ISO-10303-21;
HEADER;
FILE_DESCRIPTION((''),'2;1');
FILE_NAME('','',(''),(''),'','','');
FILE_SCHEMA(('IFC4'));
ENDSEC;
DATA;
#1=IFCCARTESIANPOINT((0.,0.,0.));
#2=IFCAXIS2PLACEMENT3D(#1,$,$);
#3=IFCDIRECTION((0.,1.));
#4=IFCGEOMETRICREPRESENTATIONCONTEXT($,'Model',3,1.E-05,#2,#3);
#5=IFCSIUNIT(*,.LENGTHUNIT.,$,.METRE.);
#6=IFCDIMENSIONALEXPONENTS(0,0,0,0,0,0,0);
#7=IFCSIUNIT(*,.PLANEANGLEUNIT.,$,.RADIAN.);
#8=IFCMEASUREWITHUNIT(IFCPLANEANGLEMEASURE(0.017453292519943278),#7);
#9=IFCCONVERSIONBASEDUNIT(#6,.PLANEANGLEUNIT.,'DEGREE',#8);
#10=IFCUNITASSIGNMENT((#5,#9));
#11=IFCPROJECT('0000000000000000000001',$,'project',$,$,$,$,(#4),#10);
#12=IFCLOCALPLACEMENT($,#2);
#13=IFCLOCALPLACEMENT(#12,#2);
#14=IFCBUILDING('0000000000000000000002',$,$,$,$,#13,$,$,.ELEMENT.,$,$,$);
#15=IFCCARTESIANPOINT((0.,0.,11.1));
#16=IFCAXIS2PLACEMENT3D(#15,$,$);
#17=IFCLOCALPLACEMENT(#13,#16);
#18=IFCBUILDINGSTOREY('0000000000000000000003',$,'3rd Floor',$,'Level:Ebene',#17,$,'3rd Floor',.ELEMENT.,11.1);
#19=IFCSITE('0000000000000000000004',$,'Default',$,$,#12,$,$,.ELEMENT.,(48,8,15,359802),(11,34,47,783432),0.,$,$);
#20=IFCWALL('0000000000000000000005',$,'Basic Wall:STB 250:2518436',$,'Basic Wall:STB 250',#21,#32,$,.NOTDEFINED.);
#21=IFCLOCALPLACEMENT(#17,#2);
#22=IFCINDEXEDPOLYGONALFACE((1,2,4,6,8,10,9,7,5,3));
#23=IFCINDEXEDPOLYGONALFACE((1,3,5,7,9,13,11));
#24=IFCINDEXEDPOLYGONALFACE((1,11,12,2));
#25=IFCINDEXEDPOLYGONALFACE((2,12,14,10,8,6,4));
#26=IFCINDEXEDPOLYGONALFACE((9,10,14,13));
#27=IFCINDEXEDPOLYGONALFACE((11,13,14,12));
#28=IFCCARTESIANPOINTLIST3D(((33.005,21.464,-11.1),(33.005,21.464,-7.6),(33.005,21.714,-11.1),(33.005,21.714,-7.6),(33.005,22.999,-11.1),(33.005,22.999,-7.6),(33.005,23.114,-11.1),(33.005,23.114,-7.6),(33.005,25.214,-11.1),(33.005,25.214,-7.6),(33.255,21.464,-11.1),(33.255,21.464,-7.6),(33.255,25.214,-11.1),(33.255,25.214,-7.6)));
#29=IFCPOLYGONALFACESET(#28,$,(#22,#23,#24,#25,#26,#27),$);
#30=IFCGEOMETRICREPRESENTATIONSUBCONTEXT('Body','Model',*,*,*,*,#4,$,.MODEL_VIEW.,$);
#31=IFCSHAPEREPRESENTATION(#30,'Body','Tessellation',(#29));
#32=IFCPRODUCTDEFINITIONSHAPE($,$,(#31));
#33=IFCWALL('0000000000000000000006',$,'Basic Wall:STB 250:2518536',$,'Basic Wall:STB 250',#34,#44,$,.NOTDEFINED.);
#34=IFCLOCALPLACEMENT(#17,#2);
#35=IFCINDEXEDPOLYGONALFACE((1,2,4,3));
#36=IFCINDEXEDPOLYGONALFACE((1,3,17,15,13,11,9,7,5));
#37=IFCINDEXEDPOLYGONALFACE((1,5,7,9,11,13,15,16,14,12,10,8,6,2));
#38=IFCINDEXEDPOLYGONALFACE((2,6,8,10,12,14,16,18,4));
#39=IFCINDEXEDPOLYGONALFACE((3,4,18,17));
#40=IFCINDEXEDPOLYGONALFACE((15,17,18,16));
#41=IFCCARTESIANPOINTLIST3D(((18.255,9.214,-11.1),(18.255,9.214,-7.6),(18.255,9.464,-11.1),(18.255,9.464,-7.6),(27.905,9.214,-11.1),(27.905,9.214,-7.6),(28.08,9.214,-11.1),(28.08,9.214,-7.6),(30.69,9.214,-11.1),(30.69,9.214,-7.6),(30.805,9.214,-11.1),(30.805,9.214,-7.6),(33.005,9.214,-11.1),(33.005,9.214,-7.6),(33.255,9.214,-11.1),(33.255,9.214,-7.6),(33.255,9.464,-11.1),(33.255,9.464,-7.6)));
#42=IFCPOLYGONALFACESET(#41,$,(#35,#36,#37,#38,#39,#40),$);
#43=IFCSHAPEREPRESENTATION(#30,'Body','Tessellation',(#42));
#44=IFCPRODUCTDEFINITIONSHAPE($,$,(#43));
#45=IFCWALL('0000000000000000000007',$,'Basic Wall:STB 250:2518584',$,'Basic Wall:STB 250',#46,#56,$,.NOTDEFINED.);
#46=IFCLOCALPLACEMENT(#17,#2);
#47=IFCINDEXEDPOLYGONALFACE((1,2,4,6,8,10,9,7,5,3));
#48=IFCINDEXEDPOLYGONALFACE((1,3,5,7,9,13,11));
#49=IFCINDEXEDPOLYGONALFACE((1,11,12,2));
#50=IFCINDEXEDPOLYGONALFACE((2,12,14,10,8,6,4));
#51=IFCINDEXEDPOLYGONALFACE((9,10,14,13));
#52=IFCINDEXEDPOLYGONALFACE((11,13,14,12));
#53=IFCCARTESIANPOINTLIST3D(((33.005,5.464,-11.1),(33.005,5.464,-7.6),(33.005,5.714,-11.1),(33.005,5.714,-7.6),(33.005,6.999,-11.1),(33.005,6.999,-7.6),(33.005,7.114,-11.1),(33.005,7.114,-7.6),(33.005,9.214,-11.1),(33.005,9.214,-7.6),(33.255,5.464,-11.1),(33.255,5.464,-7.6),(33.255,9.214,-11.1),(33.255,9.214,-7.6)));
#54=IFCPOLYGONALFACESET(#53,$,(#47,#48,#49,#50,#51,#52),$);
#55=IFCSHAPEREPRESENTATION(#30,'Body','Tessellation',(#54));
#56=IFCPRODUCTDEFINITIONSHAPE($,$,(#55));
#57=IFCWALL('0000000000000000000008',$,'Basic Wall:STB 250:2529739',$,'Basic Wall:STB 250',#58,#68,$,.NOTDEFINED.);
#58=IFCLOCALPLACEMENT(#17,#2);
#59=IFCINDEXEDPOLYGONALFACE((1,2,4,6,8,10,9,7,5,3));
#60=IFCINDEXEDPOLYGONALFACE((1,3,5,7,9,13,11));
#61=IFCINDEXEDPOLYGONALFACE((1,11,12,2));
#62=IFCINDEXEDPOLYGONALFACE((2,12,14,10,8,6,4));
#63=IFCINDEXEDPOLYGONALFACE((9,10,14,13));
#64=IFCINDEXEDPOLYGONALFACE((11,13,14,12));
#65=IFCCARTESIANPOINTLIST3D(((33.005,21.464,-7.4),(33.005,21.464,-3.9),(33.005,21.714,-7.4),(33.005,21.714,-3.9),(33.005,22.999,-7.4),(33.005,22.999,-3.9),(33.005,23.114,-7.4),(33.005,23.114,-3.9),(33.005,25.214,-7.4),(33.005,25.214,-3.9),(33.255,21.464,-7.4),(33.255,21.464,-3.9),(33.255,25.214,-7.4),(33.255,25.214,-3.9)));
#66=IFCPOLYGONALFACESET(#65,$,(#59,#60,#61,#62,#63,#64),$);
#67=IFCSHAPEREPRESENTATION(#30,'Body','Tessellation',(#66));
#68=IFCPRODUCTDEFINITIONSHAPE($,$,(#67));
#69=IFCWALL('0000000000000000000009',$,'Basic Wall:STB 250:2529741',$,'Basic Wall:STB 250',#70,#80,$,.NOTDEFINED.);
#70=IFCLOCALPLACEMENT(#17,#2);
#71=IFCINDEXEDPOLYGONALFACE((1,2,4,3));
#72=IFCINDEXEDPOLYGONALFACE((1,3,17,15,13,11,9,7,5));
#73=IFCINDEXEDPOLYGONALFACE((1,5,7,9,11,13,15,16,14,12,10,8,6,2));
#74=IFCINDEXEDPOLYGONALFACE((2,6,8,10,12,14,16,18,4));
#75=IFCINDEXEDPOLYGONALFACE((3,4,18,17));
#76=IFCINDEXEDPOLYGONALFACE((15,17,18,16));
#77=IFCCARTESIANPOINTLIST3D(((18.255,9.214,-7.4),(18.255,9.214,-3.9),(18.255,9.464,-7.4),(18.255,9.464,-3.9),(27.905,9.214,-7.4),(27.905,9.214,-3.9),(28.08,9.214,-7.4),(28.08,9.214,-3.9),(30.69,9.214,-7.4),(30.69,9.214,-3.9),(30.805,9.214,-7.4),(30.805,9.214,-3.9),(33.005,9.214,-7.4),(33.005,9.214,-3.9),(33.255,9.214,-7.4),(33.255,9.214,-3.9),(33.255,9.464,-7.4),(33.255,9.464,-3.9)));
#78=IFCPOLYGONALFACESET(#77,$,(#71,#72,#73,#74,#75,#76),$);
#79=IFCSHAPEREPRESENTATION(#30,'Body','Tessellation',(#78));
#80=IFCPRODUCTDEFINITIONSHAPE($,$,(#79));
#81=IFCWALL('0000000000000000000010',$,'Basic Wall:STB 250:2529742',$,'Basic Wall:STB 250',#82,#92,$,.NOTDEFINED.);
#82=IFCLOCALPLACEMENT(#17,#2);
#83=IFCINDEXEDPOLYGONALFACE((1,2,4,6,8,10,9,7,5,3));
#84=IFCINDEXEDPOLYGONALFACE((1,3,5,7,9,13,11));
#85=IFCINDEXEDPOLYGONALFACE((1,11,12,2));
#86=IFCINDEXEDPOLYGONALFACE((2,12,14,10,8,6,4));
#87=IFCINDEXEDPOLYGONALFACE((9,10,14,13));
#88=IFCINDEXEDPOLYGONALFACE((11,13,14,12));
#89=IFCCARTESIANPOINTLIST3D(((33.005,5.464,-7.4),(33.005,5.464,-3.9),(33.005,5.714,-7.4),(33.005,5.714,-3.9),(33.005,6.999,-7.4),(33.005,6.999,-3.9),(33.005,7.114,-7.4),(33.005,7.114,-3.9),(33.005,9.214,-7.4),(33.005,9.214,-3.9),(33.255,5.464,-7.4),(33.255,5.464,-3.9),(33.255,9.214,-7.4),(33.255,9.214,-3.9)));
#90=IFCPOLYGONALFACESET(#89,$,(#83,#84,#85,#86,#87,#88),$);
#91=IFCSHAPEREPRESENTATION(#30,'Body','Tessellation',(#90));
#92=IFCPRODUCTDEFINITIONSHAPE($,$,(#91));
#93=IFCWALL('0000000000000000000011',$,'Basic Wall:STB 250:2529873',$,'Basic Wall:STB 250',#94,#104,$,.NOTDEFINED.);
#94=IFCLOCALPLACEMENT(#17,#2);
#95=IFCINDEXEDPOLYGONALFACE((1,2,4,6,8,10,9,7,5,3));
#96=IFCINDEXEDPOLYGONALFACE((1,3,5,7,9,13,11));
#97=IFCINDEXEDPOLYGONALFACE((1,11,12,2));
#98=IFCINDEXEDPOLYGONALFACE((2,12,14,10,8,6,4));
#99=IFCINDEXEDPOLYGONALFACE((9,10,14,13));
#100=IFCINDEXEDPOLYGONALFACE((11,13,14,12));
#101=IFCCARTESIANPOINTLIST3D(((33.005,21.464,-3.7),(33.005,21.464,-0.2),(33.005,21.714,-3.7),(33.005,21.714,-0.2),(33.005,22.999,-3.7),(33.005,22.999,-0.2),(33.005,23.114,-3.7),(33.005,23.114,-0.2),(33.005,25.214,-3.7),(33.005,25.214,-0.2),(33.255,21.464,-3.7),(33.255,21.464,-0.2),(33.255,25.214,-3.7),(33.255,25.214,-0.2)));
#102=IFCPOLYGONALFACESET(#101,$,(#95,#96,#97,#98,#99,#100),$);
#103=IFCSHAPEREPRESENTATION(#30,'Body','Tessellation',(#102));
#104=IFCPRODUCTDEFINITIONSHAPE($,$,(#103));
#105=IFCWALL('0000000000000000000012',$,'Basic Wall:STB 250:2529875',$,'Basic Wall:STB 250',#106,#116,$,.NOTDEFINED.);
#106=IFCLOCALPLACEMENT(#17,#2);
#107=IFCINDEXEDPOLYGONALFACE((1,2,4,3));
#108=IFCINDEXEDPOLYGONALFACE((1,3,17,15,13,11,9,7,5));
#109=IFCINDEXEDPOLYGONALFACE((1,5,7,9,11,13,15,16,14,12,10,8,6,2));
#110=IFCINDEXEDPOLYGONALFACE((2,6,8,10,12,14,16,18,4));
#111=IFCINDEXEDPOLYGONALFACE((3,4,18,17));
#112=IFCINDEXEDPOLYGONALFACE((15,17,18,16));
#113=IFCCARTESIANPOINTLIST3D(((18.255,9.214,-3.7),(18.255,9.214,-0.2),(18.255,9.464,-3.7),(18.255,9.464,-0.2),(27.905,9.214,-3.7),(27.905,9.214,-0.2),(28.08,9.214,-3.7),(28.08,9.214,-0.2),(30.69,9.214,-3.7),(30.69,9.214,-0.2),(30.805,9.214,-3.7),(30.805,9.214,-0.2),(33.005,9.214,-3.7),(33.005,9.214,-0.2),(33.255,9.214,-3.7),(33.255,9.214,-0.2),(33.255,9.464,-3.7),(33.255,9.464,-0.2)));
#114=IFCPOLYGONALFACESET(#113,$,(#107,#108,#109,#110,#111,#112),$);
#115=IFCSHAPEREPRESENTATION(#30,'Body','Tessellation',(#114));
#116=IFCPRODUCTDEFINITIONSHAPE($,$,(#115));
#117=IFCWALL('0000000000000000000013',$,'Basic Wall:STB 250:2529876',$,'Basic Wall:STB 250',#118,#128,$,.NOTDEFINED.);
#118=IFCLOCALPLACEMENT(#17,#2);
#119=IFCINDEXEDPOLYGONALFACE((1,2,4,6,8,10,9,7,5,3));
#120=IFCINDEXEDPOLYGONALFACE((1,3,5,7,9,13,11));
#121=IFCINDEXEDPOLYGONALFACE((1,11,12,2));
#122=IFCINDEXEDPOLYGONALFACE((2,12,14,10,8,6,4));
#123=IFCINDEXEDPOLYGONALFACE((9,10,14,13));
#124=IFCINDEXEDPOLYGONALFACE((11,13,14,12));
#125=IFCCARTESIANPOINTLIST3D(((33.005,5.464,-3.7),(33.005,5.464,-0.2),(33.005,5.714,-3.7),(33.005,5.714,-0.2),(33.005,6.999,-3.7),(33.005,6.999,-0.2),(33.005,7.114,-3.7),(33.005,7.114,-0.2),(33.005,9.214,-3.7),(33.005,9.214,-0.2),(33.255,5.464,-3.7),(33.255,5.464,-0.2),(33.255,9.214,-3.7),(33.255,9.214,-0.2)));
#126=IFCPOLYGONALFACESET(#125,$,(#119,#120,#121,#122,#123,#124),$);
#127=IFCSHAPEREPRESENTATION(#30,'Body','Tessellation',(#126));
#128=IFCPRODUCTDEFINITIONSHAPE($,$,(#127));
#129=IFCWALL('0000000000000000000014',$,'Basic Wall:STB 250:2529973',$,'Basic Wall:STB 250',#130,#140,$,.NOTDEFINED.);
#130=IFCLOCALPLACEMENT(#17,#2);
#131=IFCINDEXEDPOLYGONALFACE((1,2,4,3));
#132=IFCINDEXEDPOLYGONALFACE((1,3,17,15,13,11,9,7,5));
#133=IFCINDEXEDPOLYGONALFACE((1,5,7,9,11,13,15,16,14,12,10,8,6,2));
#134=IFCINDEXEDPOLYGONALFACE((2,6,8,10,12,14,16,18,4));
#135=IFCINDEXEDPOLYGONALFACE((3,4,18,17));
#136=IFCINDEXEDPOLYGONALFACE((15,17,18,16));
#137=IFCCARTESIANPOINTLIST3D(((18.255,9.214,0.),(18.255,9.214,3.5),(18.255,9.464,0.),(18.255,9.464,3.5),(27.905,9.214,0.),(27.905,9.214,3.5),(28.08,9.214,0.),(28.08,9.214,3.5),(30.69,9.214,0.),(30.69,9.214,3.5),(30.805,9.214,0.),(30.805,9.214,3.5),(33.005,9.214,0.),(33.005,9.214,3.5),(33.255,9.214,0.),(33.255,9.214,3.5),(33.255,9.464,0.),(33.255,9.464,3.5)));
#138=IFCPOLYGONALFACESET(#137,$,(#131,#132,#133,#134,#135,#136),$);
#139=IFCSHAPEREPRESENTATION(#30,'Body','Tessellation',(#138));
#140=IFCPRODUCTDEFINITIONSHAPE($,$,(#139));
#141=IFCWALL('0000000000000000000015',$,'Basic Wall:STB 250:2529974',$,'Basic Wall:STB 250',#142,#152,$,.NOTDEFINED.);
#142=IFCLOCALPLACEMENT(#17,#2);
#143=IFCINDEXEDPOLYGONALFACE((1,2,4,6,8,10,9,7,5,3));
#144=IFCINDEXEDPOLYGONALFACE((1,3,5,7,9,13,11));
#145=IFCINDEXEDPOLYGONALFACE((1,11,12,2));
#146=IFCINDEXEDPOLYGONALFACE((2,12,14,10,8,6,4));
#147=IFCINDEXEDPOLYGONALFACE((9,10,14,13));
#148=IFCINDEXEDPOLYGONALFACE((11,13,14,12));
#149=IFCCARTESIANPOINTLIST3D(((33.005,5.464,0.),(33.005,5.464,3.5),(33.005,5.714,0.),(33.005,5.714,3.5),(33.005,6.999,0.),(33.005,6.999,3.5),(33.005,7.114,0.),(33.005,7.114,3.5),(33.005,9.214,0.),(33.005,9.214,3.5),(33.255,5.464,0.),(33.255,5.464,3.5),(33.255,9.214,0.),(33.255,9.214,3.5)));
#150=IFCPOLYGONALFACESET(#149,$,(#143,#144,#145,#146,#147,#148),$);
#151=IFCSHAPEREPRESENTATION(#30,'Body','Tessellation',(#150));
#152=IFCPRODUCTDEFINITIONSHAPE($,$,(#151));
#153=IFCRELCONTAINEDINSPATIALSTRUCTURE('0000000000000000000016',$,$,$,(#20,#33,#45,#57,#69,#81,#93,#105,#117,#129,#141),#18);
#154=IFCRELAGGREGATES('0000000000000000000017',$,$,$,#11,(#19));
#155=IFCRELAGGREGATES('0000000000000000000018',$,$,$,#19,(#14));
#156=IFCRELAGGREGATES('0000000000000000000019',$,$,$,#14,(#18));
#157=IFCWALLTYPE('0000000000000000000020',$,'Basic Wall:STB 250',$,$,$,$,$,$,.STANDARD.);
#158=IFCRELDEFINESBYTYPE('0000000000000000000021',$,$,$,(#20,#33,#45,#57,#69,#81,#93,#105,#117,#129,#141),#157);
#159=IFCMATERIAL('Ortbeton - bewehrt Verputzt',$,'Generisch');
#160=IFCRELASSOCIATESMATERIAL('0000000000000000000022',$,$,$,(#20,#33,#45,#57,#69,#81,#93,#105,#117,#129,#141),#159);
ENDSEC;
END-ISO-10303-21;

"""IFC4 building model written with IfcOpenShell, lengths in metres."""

from ifc_helpers import new_model, entity, si_unit, converted_unit, direction, frame, origin, place, context, subcontext, project, spatial, indexed_curve, outline, extrude, material, type_object, element, save


model = new_model("IFC4")

# Units and contexts
model_context = context("Model", 3, precision=1e-05, world=origin(), true_north=direction((0.0, 1.0)))
body_context = subcontext(model_context, "Body", "Model", "MODEL_VIEW")
ifc_project = project(units=[si_unit("LENGTHUNIT", "METRE"), converted_unit("PLANEANGLEUNIT", "DEGREE", entity("IfcPlaneAngleMeasure", 0.017453292519943278), si_unit("PLANEANGLEUNIT", "RADIAN"), dimensions=[0, 0, 0, 0, 0, 0, 0])], contexts=[model_context])

# Site, building, storey
site_placement = place(None, origin())
site = spatial("IfcSite", under=ifc_project, at=site_placement, Name="Default", CompositionType="ELEMENT", RefLatitude=(48, 8, 15, 359802), RefLongitude=(11, 34, 47, 783432), RefElevation=0.0)
building_placement = place(site_placement, origin())
building = spatial("IfcBuilding", under=site, at=building_placement, CompositionType="ELEMENT")
storey_placement = place(building_placement, frame((0.0, 0.0, 11.1)))
storey = spatial("IfcBuildingStorey", under=building, at=storey_placement, Name="3rd Floor", ObjectType="Level:Ebene", LongName="3rd Floor", CompositionType="ELEMENT", Elevation=11.1)

# Walls
ifc_material_1 = material(Name="Ortbeton - bewehrt Verputzt", Category="Generisch")
wall_type_1 = type_object("IfcWallType", Name="Basic Wall:STB 250", PredefinedType="STANDARD")
wall_1_placement = place(storey_placement, frame((33.13, 25.214, -11.1), z_axis=(0.0, 0.0, 1.0), x_axis=(0.0, -1.0, 0.0)))
element("IfcWall", 1, at=wall_1_placement, inside=storey, type_object=wall_type_1, material=ifc_material_1, Name="Basic Wall:STB 250:2518436", ObjectType="Basic Wall:STB 250", PredefinedType="NOTDEFINED", context=body_context, shape_type="SweptSolid", body=[
    extrude(outline(indexed_curve([(3.75, -0.125), (3.75, 0.125), (0.0, 0.125), (0.0, -0.125), (2.1, -0.125), (2.215, -0.125), (3.5, -0.125), (3.75, -0.125)], self_intersect=False)), origin(), (0.0, 0.0, 1.0), 3.5),
])
wall_2_placement = place(storey_placement, frame((18.255, 9.339, -11.1)))
element("IfcWall", 2, at=wall_2_placement, inside=storey, type_object=wall_type_1, material=ifc_material_1, Name="Basic Wall:STB 250:2518536", ObjectType="Basic Wall:STB 250", PredefinedType="NOTDEFINED", context=body_context, shape_type="SweptSolid", body=[
    extrude(outline(indexed_curve([(15.0, -0.125), (15.0, 0.125), (0.0, 0.125), (0.0, -0.125), (9.65, -0.125), (9.825, -0.125), (12.435, -0.125), (12.55, -0.125), (14.75, -0.125), (15.0, -0.125)], self_intersect=False)), origin(), (0.0, 0.0, 1.0), 3.5),
])
wall_3_placement = place(storey_placement, frame((33.13, 9.214, -11.1), z_axis=(0.0, 0.0, 1.0), x_axis=(0.0, -1.0, 0.0)))
element("IfcWall", 3, at=wall_3_placement, inside=storey, type_object=wall_type_1, material=ifc_material_1, Name="Basic Wall:STB 250:2518584", ObjectType="Basic Wall:STB 250", PredefinedType="NOTDEFINED", context=body_context, shape_type="SweptSolid", body=[
    extrude(outline(indexed_curve([(3.75, -0.125), (3.75, 0.125), (0.0, 0.125), (0.0, -0.125), (2.1, -0.125), (2.215, -0.125), (3.5, -0.125), (3.75, -0.125)], self_intersect=False)), origin(), (0.0, 0.0, 1.0), 3.5),
])
wall_4_placement = place(storey_placement, frame((33.13, 25.214, -7.4), z_axis=(0.0, 0.0, 1.0), x_axis=(0.0, -1.0, 0.0)))
element("IfcWall", 4, at=wall_4_placement, inside=storey, type_object=wall_type_1, material=ifc_material_1, Name="Basic Wall:STB 250:2529739", ObjectType="Basic Wall:STB 250", PredefinedType="NOTDEFINED", context=body_context, shape_type="SweptSolid", body=[
    extrude(outline(indexed_curve([(3.75, -0.125), (3.75, 0.125), (0.0, 0.125), (0.0, -0.125), (2.1, -0.125), (2.215, -0.125), (3.5, -0.125), (3.75, -0.125)], self_intersect=False)), origin(), (0.0, 0.0, 1.0), 3.5),
])
wall_5_placement = place(storey_placement, frame((18.255, 9.339, -7.4)))
element("IfcWall", 5, at=wall_5_placement, inside=storey, type_object=wall_type_1, material=ifc_material_1, Name="Basic Wall:STB 250:2529741", ObjectType="Basic Wall:STB 250", PredefinedType="NOTDEFINED", context=body_context, shape_type="SweptSolid", body=[
    extrude(outline(indexed_curve([(15.0, -0.125), (15.0, 0.125), (0.0, 0.125), (0.0, -0.125), (9.65, -0.125), (9.825, -0.125), (12.435, -0.125), (12.55, -0.125), (14.75, -0.125), (15.0, -0.125)], self_intersect=False)), origin(), (0.0, 0.0, 1.0), 3.5),
])
wall_6_placement = place(storey_placement, frame((33.13, 9.214, -7.4), z_axis=(0.0, 0.0, 1.0), x_axis=(0.0, -1.0, 0.0)))
element("IfcWall", 6, at=wall_6_placement, inside=storey, type_object=wall_type_1, material=ifc_material_1, Name="Basic Wall:STB 250:2529742", ObjectType="Basic Wall:STB 250", PredefinedType="NOTDEFINED", context=body_context, shape_type="SweptSolid", body=[
    extrude(outline(indexed_curve([(3.75, -0.125), (3.75, 0.125), (0.0, 0.125), (0.0, -0.125), (2.1, -0.125), (2.215, -0.125), (3.5, -0.125), (3.75, -0.125)], self_intersect=False)), origin(), (0.0, 0.0, 1.0), 3.5),
])
wall_7_placement = place(storey_placement, frame((33.13, 25.214, -3.7), z_axis=(0.0, 0.0, 1.0), x_axis=(0.0, -1.0, 0.0)))
element("IfcWall", 7, at=wall_7_placement, inside=storey, type_object=wall_type_1, material=ifc_material_1, Name="Basic Wall:STB 250:2529873", ObjectType="Basic Wall:STB 250", PredefinedType="NOTDEFINED", context=body_context, shape_type="SweptSolid", body=[
    extrude(outline(indexed_curve([(3.75, -0.125), (3.75, 0.125), (0.0, 0.125), (0.0, -0.125), (2.1, -0.125), (2.215, -0.125), (3.5, -0.125), (3.75, -0.125)], self_intersect=False)), origin(), (0.0, 0.0, 1.0), 3.5),
])
wall_8_placement = place(storey_placement, frame((18.255, 9.339, -3.7)))
element("IfcWall", 8, at=wall_8_placement, inside=storey, type_object=wall_type_1, material=ifc_material_1, Name="Basic Wall:STB 250:2529875", ObjectType="Basic Wall:STB 250", PredefinedType="NOTDEFINED", context=body_context, shape_type="SweptSolid", body=[
    extrude(outline(indexed_curve([(15.0, -0.125), (15.0, 0.125), (0.0, 0.125), (0.0, -0.125), (9.65, -0.125), (9.825, -0.125), (12.435, -0.125), (12.55, -0.125), (14.75, -0.125), (15.0, -0.125)], self_intersect=False)), origin(), (0.0, 0.0, 1.0), 3.5),
])
wall_9_placement = place(storey_placement, frame((33.13, 9.214, -3.7), z_axis=(0.0, 0.0, 1.0), x_axis=(0.0, -1.0, 0.0)))
element("IfcWall", 9, at=wall_9_placement, inside=storey, type_object=wall_type_1, material=ifc_material_1, Name="Basic Wall:STB 250:2529876", ObjectType="Basic Wall:STB 250", PredefinedType="NOTDEFINED", context=body_context, shape_type="SweptSolid", body=[
    extrude(outline(indexed_curve([(3.75, -0.125), (3.75, 0.125), (0.0, 0.125), (0.0, -0.125), (2.1, -0.125), (2.215, -0.125), (3.5, -0.125), (3.75, -0.125)], self_intersect=False)), origin(), (0.0, 0.0, 1.0), 3.5),
])
wall_10_placement = place(storey_placement, frame((18.255, 9.339, 0.0)))
element("IfcWall", 10, at=wall_10_placement, inside=storey, type_object=wall_type_1, material=ifc_material_1, Name="Basic Wall:STB 250:2529973", ObjectType="Basic Wall:STB 250", PredefinedType="NOTDEFINED", context=body_context, shape_type="SweptSolid", body=[
    extrude(outline(indexed_curve([(15.0, -0.125), (15.0, 0.125), (0.0, 0.125), (0.0, -0.125), (9.65, -0.125), (9.825, -0.125), (12.435, -0.125), (12.55, -0.125), (14.75, -0.125), (15.0, -0.125)], self_intersect=False)), origin(), (0.0, 0.0, 1.0), 3.5),
])
wall_11_placement = place(storey_placement, frame((33.13, 9.214, 0.0), z_axis=(0.0, 0.0, 1.0), x_axis=(0.0, -1.0, 0.0)))
element("IfcWall", 11, at=wall_11_placement, inside=storey, type_object=wall_type_1, material=ifc_material_1, Name="Basic Wall:STB 250:2529974", ObjectType="Basic Wall:STB 250", PredefinedType="NOTDEFINED", context=body_context, shape_type="SweptSolid", body=[
    extrude(outline(indexed_curve([(3.75, -0.125), (3.75, 0.125), (0.0, 0.125), (0.0, -0.125), (2.1, -0.125), (2.215, -0.125), (3.5, -0.125), (3.75, -0.125)], self_intersect=False)), origin(), (0.0, 0.0, 1.0), 3.5),
])

save(model, "model.ifc")
